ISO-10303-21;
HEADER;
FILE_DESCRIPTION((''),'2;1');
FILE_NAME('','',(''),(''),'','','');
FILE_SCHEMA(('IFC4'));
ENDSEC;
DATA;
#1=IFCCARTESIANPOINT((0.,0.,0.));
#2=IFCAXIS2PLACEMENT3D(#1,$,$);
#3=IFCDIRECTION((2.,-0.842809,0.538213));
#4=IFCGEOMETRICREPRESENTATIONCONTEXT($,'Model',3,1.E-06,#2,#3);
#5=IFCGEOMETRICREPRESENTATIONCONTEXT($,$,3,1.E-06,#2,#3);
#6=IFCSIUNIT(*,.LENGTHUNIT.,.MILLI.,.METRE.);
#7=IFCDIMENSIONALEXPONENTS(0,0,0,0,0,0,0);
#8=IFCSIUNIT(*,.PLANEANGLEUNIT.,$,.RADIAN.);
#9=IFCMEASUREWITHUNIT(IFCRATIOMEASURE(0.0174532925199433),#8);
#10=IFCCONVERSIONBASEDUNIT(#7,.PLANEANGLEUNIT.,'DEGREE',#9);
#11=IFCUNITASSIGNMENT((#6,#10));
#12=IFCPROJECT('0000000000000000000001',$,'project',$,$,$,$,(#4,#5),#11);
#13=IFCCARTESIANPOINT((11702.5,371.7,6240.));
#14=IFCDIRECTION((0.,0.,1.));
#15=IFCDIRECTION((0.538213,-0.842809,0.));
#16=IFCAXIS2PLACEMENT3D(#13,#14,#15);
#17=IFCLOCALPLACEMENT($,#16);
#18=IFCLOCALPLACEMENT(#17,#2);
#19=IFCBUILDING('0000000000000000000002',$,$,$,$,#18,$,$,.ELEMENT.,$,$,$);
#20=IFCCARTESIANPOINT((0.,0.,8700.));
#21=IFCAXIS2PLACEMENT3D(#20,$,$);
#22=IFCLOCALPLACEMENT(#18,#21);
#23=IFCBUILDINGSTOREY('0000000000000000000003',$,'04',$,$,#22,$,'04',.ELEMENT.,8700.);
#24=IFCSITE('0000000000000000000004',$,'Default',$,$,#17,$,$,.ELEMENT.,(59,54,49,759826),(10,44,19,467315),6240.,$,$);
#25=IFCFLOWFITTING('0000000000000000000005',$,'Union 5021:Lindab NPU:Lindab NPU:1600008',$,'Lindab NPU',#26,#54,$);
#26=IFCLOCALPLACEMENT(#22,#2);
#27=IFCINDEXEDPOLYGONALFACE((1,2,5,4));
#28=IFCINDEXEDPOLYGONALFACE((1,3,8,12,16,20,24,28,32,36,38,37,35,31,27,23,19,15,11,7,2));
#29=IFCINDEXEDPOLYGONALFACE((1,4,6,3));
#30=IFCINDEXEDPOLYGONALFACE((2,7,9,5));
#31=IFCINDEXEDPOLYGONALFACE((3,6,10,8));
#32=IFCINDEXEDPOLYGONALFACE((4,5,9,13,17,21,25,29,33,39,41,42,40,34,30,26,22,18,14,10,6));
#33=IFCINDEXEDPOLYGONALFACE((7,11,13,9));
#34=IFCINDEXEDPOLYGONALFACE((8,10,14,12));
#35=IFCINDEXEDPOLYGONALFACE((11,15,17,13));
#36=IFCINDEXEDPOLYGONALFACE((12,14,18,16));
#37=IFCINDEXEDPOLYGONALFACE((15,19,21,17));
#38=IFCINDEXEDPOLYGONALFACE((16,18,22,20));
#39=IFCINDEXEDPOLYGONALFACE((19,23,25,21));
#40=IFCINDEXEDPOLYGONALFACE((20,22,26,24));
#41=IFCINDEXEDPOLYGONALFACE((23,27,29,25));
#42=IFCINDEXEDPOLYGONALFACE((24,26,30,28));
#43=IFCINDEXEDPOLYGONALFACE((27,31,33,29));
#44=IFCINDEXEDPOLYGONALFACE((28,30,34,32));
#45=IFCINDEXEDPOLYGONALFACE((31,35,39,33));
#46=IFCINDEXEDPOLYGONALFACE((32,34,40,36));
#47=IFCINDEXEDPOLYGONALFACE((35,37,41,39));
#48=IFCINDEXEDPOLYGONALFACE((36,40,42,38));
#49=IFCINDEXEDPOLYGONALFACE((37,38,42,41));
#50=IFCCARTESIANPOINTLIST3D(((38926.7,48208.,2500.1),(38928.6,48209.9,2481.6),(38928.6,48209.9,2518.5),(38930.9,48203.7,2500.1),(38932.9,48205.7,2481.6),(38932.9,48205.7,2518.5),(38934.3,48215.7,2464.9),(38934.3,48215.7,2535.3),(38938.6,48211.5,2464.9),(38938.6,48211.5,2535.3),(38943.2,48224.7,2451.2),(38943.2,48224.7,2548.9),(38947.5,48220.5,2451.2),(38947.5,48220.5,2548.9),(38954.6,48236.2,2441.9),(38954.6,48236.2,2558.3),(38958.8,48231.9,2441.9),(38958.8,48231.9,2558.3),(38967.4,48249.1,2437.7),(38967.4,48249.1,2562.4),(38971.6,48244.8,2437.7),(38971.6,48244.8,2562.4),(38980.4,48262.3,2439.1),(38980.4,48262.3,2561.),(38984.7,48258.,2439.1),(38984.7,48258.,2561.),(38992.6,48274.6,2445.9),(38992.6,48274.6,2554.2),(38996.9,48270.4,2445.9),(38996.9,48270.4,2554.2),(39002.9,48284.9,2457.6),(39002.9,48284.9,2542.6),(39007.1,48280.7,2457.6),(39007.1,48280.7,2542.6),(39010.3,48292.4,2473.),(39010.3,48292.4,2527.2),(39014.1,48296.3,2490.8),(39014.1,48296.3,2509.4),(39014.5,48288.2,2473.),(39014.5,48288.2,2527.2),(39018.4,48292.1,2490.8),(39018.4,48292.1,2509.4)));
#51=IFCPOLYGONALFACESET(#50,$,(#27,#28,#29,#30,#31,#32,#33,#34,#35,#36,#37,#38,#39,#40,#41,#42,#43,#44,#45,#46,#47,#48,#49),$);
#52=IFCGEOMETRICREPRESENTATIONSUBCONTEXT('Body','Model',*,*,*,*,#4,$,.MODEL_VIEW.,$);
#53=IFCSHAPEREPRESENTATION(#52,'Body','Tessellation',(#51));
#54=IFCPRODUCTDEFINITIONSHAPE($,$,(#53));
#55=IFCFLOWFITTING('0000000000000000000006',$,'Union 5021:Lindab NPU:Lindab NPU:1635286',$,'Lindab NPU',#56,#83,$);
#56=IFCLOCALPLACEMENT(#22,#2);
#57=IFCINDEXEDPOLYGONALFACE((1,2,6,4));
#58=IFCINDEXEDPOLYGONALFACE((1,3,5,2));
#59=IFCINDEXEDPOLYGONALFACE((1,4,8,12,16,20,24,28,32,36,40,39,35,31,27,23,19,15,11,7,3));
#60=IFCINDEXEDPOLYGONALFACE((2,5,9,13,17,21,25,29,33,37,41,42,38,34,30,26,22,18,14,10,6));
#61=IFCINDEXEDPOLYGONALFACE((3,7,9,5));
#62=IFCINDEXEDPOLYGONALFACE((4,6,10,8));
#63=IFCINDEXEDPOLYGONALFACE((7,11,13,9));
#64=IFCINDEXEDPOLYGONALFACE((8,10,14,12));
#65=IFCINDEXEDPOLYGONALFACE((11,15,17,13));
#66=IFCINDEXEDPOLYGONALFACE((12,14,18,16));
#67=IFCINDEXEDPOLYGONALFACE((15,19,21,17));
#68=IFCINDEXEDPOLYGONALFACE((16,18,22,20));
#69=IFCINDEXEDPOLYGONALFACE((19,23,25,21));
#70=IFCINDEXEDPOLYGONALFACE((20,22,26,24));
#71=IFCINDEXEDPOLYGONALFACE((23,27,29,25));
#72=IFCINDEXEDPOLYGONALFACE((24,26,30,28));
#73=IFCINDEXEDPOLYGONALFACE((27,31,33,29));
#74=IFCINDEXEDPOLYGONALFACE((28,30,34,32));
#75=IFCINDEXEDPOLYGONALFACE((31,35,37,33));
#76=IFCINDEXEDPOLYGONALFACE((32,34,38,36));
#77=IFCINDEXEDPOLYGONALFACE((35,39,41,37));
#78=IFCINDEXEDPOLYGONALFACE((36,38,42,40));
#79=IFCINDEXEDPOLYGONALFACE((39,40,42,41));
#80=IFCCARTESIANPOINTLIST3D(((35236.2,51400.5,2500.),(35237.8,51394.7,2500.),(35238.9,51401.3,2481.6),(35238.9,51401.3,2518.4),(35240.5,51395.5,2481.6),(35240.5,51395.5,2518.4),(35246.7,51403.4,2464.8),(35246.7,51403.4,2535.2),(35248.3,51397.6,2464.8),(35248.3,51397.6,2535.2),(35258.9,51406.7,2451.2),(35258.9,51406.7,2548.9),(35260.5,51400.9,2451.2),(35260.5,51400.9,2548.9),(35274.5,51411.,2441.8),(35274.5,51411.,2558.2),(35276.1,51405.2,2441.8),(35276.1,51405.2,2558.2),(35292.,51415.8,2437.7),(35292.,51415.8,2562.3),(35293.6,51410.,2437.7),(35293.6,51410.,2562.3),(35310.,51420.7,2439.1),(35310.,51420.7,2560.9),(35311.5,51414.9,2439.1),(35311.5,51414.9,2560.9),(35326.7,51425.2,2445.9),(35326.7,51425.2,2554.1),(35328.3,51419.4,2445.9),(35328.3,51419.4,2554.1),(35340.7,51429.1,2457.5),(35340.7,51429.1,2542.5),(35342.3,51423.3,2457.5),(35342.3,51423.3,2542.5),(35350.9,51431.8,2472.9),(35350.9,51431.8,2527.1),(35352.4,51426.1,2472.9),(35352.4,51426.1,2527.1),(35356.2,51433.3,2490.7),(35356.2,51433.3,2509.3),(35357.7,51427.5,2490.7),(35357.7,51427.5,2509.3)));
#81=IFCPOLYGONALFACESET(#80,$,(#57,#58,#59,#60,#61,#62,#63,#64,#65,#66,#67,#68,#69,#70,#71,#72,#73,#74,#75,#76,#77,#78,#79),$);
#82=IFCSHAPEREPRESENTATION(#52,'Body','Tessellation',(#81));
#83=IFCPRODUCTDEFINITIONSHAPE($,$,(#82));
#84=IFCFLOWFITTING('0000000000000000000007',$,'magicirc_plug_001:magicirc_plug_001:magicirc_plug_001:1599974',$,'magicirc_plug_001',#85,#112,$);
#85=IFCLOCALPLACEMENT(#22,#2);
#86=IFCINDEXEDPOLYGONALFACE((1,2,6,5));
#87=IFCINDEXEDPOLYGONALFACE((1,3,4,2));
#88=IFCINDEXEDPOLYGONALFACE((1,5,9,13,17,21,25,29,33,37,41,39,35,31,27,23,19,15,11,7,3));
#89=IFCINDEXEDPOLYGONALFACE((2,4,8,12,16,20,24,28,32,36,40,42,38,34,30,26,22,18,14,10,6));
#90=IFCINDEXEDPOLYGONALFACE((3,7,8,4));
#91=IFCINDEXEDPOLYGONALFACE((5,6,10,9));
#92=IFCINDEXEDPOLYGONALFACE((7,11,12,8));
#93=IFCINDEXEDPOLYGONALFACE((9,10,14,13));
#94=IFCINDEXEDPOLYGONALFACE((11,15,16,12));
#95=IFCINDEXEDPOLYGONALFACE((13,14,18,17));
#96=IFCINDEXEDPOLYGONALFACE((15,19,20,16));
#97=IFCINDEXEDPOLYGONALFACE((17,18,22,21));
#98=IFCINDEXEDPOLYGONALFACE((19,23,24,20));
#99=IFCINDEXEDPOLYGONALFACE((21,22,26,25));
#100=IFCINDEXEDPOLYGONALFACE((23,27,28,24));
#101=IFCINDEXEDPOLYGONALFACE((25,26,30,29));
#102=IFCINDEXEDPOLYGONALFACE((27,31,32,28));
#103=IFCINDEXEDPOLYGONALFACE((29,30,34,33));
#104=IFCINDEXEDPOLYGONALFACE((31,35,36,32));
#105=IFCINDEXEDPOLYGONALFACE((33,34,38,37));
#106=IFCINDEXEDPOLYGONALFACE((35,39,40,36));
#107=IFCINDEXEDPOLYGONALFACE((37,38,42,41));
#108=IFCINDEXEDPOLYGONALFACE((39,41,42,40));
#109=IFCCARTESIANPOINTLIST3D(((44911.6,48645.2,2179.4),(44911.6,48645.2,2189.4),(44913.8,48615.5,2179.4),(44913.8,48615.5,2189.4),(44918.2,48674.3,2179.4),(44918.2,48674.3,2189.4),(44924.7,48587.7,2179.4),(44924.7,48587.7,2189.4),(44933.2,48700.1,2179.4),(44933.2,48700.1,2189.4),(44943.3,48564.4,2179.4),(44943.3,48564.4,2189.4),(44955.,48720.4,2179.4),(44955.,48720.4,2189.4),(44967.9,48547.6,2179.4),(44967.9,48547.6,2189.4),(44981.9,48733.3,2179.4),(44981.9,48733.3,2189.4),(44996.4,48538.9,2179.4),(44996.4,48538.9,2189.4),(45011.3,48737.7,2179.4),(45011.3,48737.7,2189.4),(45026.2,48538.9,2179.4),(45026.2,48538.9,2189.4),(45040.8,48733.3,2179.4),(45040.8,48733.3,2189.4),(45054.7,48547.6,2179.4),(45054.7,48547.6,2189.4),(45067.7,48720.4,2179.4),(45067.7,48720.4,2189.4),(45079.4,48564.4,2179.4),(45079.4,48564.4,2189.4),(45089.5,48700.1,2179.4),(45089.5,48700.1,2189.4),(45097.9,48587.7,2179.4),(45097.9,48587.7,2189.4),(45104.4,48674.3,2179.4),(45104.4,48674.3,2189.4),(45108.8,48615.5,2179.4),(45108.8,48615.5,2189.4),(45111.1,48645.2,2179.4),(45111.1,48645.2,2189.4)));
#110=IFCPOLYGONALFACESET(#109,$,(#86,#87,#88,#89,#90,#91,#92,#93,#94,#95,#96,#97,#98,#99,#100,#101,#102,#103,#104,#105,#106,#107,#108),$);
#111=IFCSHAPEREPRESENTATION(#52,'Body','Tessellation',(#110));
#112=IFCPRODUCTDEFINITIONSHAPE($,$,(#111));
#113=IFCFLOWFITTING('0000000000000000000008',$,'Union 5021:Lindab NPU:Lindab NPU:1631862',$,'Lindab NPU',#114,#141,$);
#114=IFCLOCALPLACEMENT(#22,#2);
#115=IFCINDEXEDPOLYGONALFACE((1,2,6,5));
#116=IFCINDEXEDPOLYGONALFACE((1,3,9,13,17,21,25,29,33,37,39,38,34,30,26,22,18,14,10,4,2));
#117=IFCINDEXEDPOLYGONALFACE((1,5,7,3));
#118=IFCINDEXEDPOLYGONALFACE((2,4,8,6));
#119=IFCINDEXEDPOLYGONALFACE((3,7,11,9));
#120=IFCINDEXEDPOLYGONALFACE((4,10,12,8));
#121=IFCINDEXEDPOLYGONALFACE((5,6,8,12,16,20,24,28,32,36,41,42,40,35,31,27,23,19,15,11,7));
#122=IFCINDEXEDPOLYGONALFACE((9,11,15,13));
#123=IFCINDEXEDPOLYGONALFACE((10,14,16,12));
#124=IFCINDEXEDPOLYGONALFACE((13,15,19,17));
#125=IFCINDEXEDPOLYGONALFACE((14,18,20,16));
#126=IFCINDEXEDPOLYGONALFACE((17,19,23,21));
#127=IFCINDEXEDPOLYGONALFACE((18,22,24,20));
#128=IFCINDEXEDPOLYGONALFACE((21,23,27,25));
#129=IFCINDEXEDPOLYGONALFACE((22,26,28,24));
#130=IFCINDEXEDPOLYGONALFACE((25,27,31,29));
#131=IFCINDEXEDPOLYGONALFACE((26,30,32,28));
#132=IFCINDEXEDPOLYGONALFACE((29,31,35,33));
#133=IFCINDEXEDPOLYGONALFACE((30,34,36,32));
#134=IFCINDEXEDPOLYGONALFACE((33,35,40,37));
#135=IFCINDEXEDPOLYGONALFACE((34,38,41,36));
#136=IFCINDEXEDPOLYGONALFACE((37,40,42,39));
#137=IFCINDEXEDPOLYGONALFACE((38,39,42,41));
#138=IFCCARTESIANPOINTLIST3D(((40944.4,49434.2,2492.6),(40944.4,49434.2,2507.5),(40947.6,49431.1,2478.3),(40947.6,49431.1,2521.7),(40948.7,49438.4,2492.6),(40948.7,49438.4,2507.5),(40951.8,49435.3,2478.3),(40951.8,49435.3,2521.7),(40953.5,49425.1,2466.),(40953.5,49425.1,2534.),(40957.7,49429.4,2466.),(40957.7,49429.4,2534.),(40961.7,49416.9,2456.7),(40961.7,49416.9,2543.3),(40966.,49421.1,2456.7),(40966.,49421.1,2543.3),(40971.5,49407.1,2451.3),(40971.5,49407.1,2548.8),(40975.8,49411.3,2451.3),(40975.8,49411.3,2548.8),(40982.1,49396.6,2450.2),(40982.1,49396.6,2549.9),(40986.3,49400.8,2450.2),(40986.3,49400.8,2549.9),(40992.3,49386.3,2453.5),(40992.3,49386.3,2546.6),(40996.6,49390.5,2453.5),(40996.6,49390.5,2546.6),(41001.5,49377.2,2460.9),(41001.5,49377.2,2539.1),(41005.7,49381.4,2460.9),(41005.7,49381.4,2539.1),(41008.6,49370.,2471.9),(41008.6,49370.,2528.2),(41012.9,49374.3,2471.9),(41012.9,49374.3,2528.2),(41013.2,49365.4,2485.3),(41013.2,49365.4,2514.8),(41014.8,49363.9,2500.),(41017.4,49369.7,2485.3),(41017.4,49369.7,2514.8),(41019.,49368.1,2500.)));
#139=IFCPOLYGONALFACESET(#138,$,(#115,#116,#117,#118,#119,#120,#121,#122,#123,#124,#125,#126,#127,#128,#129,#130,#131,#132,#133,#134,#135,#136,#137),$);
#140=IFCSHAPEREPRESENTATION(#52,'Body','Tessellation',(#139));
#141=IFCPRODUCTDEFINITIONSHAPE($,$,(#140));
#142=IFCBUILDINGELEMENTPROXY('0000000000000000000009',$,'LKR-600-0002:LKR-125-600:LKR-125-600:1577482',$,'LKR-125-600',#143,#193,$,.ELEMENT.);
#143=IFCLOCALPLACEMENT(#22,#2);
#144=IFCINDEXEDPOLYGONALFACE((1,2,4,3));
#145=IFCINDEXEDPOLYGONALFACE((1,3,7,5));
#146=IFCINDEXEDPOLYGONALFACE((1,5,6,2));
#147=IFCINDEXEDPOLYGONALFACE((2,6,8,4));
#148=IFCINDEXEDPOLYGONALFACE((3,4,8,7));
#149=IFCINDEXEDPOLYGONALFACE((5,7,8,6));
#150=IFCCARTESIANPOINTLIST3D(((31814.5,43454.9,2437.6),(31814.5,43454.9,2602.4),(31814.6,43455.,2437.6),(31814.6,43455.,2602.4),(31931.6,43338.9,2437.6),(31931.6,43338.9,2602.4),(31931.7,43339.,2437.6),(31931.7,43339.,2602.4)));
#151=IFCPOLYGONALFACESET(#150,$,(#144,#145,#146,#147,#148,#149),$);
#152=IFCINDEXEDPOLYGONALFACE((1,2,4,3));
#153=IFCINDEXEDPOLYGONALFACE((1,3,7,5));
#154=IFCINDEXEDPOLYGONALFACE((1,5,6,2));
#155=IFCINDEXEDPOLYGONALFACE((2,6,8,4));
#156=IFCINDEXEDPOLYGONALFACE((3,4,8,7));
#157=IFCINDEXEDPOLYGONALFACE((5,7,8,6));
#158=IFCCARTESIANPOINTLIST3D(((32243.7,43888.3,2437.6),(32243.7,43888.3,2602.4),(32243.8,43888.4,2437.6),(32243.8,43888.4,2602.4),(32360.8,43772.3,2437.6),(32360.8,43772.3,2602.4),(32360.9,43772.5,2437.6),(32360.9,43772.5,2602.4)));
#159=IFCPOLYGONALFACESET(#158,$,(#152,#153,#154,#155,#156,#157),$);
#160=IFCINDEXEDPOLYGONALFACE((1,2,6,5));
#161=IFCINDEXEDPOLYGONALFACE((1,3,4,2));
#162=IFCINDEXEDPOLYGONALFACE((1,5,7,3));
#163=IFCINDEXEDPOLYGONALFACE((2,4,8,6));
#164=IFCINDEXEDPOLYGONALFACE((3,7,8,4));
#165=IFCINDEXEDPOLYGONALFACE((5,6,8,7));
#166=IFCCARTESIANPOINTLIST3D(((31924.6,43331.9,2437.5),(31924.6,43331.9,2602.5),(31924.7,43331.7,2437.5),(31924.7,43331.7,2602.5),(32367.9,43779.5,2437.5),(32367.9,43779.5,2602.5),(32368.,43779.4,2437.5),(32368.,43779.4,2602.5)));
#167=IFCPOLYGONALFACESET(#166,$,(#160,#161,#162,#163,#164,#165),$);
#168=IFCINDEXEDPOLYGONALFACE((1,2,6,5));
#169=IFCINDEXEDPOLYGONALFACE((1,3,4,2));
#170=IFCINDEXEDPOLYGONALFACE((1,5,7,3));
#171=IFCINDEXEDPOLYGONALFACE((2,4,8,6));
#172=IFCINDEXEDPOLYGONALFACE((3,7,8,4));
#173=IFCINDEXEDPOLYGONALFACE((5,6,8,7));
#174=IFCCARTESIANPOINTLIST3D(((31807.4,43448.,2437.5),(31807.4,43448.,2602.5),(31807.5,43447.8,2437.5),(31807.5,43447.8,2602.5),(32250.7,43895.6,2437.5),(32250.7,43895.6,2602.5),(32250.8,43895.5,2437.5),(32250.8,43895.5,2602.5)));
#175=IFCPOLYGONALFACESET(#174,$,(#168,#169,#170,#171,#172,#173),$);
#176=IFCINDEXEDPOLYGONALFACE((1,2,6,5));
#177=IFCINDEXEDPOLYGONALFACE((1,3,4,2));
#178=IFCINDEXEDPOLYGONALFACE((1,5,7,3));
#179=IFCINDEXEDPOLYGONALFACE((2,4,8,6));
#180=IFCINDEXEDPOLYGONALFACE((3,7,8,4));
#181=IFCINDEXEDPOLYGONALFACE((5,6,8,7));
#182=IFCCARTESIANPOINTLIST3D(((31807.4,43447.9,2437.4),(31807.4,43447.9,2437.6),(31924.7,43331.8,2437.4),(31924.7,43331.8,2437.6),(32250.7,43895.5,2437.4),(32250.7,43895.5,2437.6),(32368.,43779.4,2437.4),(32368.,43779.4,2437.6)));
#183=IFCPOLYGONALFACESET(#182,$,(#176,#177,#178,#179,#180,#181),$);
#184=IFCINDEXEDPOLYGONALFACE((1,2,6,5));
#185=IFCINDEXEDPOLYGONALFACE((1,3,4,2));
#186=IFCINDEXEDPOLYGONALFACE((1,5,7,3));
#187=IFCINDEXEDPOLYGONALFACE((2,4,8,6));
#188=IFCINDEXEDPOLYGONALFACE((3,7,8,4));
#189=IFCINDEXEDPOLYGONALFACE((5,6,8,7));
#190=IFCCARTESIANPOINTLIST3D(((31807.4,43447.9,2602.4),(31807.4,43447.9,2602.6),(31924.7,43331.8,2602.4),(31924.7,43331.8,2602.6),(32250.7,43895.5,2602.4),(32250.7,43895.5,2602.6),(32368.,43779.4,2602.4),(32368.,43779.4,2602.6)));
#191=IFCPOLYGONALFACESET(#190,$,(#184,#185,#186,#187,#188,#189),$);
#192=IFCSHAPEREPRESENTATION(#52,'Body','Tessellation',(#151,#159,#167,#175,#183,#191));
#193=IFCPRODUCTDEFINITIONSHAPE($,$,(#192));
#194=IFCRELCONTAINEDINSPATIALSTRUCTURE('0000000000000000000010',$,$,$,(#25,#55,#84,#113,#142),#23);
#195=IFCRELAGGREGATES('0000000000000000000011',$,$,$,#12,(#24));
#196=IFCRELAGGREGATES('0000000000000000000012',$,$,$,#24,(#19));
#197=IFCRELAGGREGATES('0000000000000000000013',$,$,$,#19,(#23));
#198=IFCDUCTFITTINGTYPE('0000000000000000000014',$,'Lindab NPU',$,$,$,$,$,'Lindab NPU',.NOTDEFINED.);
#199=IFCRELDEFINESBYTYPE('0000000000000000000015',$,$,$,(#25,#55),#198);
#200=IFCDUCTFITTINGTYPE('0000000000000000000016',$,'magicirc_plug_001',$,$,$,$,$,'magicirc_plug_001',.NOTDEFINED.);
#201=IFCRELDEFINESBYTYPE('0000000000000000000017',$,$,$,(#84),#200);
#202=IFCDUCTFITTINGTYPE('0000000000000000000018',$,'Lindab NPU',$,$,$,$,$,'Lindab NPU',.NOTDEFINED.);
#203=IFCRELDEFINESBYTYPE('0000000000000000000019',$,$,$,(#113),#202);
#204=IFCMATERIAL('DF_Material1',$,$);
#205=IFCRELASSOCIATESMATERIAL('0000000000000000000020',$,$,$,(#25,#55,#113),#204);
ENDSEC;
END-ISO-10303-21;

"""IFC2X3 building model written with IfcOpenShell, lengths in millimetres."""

from ifc_helpers import new_model, entity, si_unit, converted_unit, direction, frame, frame_2d, origin, place, context, subcontext, project, spatial, rectangle, circle, extrude, source, transform, mapped, material, type_object, type_shapes, element, save


model = new_model("IFC2X3")

# Units and contexts
model_context = context("Model", 3, precision=1e-06, world=origin(), true_north=direction((2.0, -0.842809, 0.538213)))
context_of_model = context(None, 3, precision=1e-06, world=origin(), true_north=direction((2.0, -0.842809, 0.538213)))
body_context = subcontext(model_context, "Body", "Model", "MODEL_VIEW")
ifc_project = project(units=[si_unit("LENGTHUNIT", "METRE", prefix="MILLI"), converted_unit("PLANEANGLEUNIT", "DEGREE", entity("IfcRatioMeasure", 0.0174532925199433), si_unit("PLANEANGLEUNIT", "RADIAN"), dimensions=[0, 0, 0, 0, 0, 0, 0])], contexts=[model_context, context_of_model])

# Site, building, storey
site_placement = place(None, frame((11702.5, 371.7, 6240.0), z_axis=(0.0, 0.0, 1.0), x_axis=(0.538213, -0.842809, 0.0)))
site = spatial("IfcSite", under=ifc_project, at=site_placement, Name="Default", CompositionType="ELEMENT", RefLatitude=(59, 54, 49, 759826), RefLongitude=(10, 44, 19, 467315), RefElevation=6240.0)
building_placement = place(site_placement, origin())
building = spatial("IfcBuilding", under=site, at=building_placement, CompositionType="ELEMENT")
storey_placement = place(building_placement, frame((0.0, 0.0, 8700.0)))
storey = spatial("IfcBuildingStorey", under=building, at=storey_placement, Name="04", LongName="04", CompositionType="ELEMENT", Elevation=8700.0)

# Flow fittings
ifc_material = material(Name="DF_Material1")
duct_fitting_type_1 = type_object("IfcDuctFittingType", Name="Lindab NPU", ElementType="Lindab NPU", PredefinedType="NOTDEFINED")
shared_shape_1 = source(origin(), body_context, "Body", "SweptSolid", [
    extrude(circle(Radius=62.5, at=frame_2d((0.0, 0.0), x_axis=(1.0, 0.0))), frame((0.0, 0.0, 0.0), z_axis=(1.0, 0.0, 0.0), x_axis=(0.0, 1.0, 0.0)), (0.0, 0.0, 1.0), 6.0),
])
type_shapes(duct_fitting_type_1, [shared_shape_1])
for number, where, z_axis, x_axis, name in (
    (1, (38974.9, 48248.2, 11200.1), (0.0, 0.0, 1.0), (-0.710554, 0.703643, 0.0), "Union 5021:Lindab NPU:Lindab NPU:1600008"),
    (2, (35298.1, 51411.2, 11200.0), (0.0, 0.0, 1.0), (-0.263536, 0.964649, 0.0), "Union 5021:Lindab NPU:Lindab NPU:1635286"),
):
    element("IfcFlowFitting", number, at=place(building_placement, frame(where, z_axis=z_axis, x_axis=x_axis)), inside=storey, type_object=duct_fitting_type_1, material=ifc_material, Name=name, ObjectType="Lindab NPU", context=body_context, shape_type="MappedRepresentation", body=[
        mapped(shared_shape_1, transform((0.0, 0.0, 0.0), scale=1.0)),
    ])
duct_fitting_type_2 = type_object("IfcDuctFittingType", Name="magicirc_plug_001", ElementType="magicirc_plug_001", PredefinedType="NOTDEFINED")
shared_shape_2 = source(origin(), body_context, "Body", "SweptSolid", [
    extrude(circle(Radius=100.0, at=frame_2d((0.0, 0.0), x_axis=(1.0, 0.0))), frame((0.0, 0.0, 0.0), z_axis=(1.0, 0.0, 0.0), x_axis=(0.0, 1.0, 0.0)), (0.0, 0.0, 1.0), 10.0),
])
type_shapes(duct_fitting_type_2, [shared_shape_2])
flow_fitting_1_placement = place(building_placement, frame((45011.3, 48637.7, 10889.4), z_axis=(1.0, 0.0, 0.0), x_axis=(0.0, 0.0, -1.0)))
element("IfcFlowFitting", 3, at=flow_fitting_1_placement, inside=storey, type_object=duct_fitting_type_2, Name="magicirc_plug_001:magicirc_plug_001:magicirc_plug_001:1599974", ObjectType="magicirc_plug_001", context=body_context, shape_type="MappedRepresentation", body=[
    mapped(shared_shape_2, transform((0.0, 0.0, 0.0), scale=1.0)),
])
duct_fitting_type_3 = type_object("IfcDuctFittingType", Name="Lindab NPU", ElementType="Lindab NPU", PredefinedType="NOTDEFINED")
shared_shape_3 = source(origin(), body_context, "Body", "SweptSolid", [
    extrude(circle(Radius=50.0, at=frame_2d((0.0, 0.0), x_axis=(1.0, 0.0))), frame((0.0, 0.0, 0.0), z_axis=(1.0, 0.0, 0.0), x_axis=(0.0, 1.0, 0.0)), (0.0, 0.0, 1.0), 6.0),
])
type_shapes(duct_fitting_type_3, [shared_shape_3])
flow_fitting_2_placement = place(building_placement, frame((40983.7, 49403.5, 11200.0), z_axis=(0.0, 0.0, 1.0), x_axis=(-0.707107, -0.707107, 0.0)))
element("IfcFlowFitting", 4, at=flow_fitting_2_placement, inside=storey, type_object=duct_fitting_type_3, material=ifc_material, Name="Union 5021:Lindab NPU:Lindab NPU:1631862", ObjectType="Lindab NPU", context=body_context, shape_type="MappedRepresentation", body=[
    mapped(shared_shape_3, transform((0.0, 0.0, 0.0), scale=1.0)),
])

# Building element proxy
shared_shape_4 = source(origin(), body_context, "Body", "SweptSolid", [
    extrude(rectangle(XDim=0.2, YDim=164.8, at=frame_2d((0.0, 0.0), x_axis=(1.0, 0.0))), frame((305.0, 0.0, -82.4)), (0.0, 0.0, 1.0), 164.8),
    extrude(rectangle(XDim=0.2, YDim=164.8, at=frame_2d((0.0, 0.0), x_axis=(1.0, 0.0))), frame((-305.0, 0.0, -82.4)), (0.0, 0.0, 1.0), 164.8),
    extrude(rectangle(XDim=0.2, YDim=630.0, at=frame_2d((0.0, 0.0), x_axis=(1.0, 0.0))), frame((0.0, 82.5, -82.5), z_axis=(0.0, 0.0, 1.0), x_axis=(0.0, 1.0, 0.0)), (0.0, 0.0, 1.0), 165.0),
    extrude(rectangle(XDim=0.2, YDim=630.0, at=frame_2d((0.0, 0.0), x_axis=(1.0, 0.0))), frame((0.0, -82.5, -82.5), z_axis=(0.0, 0.0, 1.0), x_axis=(0.0, 1.0, 0.0)), (0.0, 0.0, 1.0), 165.0),
    extrude(rectangle(XDim=165.0, YDim=630.0, at=frame_2d((0.0, 0.0), x_axis=(1.0, 0.0))), frame((0.0, 0.0, -82.6), z_axis=(0.0, 0.0, 1.0), x_axis=(0.0, -1.0, 0.0)), (0.0, 0.0, 1.0), 0.2),
    extrude(rectangle(XDim=165.0, YDim=630.0, at=frame_2d((0.0, 0.0), x_axis=(1.0, 0.0))), frame((0.0, 0.0, 82.4), z_axis=(0.0, 0.0, 1.0), x_axis=(0.0, -1.0, 0.0)), (0.0, 0.0, 1.0), 0.2),
])
for number, where, z_axis, x_axis, name in (
    (5, (32087.7, 43613.7, 11220.0), (0.0, 0.0, 1.0), (-0.703643, -0.710554, 0.0), "LKR-600-0002:LKR-125-600:LKR-125-600:1577482"),
):
    element("IfcBuildingElementProxy", number, at=place(building_placement, frame(where, z_axis=z_axis, x_axis=x_axis)), inside=storey, Name=name, ObjectType="LKR-125-600", CompositionType="ELEMENT", context=body_context, shape_type="MappedRepresentation", body=[
        mapped(shared_shape_4, transform((0.0, 0.0, 0.0), scale=1.0)),
    ])

save(model, "model.ifc")
